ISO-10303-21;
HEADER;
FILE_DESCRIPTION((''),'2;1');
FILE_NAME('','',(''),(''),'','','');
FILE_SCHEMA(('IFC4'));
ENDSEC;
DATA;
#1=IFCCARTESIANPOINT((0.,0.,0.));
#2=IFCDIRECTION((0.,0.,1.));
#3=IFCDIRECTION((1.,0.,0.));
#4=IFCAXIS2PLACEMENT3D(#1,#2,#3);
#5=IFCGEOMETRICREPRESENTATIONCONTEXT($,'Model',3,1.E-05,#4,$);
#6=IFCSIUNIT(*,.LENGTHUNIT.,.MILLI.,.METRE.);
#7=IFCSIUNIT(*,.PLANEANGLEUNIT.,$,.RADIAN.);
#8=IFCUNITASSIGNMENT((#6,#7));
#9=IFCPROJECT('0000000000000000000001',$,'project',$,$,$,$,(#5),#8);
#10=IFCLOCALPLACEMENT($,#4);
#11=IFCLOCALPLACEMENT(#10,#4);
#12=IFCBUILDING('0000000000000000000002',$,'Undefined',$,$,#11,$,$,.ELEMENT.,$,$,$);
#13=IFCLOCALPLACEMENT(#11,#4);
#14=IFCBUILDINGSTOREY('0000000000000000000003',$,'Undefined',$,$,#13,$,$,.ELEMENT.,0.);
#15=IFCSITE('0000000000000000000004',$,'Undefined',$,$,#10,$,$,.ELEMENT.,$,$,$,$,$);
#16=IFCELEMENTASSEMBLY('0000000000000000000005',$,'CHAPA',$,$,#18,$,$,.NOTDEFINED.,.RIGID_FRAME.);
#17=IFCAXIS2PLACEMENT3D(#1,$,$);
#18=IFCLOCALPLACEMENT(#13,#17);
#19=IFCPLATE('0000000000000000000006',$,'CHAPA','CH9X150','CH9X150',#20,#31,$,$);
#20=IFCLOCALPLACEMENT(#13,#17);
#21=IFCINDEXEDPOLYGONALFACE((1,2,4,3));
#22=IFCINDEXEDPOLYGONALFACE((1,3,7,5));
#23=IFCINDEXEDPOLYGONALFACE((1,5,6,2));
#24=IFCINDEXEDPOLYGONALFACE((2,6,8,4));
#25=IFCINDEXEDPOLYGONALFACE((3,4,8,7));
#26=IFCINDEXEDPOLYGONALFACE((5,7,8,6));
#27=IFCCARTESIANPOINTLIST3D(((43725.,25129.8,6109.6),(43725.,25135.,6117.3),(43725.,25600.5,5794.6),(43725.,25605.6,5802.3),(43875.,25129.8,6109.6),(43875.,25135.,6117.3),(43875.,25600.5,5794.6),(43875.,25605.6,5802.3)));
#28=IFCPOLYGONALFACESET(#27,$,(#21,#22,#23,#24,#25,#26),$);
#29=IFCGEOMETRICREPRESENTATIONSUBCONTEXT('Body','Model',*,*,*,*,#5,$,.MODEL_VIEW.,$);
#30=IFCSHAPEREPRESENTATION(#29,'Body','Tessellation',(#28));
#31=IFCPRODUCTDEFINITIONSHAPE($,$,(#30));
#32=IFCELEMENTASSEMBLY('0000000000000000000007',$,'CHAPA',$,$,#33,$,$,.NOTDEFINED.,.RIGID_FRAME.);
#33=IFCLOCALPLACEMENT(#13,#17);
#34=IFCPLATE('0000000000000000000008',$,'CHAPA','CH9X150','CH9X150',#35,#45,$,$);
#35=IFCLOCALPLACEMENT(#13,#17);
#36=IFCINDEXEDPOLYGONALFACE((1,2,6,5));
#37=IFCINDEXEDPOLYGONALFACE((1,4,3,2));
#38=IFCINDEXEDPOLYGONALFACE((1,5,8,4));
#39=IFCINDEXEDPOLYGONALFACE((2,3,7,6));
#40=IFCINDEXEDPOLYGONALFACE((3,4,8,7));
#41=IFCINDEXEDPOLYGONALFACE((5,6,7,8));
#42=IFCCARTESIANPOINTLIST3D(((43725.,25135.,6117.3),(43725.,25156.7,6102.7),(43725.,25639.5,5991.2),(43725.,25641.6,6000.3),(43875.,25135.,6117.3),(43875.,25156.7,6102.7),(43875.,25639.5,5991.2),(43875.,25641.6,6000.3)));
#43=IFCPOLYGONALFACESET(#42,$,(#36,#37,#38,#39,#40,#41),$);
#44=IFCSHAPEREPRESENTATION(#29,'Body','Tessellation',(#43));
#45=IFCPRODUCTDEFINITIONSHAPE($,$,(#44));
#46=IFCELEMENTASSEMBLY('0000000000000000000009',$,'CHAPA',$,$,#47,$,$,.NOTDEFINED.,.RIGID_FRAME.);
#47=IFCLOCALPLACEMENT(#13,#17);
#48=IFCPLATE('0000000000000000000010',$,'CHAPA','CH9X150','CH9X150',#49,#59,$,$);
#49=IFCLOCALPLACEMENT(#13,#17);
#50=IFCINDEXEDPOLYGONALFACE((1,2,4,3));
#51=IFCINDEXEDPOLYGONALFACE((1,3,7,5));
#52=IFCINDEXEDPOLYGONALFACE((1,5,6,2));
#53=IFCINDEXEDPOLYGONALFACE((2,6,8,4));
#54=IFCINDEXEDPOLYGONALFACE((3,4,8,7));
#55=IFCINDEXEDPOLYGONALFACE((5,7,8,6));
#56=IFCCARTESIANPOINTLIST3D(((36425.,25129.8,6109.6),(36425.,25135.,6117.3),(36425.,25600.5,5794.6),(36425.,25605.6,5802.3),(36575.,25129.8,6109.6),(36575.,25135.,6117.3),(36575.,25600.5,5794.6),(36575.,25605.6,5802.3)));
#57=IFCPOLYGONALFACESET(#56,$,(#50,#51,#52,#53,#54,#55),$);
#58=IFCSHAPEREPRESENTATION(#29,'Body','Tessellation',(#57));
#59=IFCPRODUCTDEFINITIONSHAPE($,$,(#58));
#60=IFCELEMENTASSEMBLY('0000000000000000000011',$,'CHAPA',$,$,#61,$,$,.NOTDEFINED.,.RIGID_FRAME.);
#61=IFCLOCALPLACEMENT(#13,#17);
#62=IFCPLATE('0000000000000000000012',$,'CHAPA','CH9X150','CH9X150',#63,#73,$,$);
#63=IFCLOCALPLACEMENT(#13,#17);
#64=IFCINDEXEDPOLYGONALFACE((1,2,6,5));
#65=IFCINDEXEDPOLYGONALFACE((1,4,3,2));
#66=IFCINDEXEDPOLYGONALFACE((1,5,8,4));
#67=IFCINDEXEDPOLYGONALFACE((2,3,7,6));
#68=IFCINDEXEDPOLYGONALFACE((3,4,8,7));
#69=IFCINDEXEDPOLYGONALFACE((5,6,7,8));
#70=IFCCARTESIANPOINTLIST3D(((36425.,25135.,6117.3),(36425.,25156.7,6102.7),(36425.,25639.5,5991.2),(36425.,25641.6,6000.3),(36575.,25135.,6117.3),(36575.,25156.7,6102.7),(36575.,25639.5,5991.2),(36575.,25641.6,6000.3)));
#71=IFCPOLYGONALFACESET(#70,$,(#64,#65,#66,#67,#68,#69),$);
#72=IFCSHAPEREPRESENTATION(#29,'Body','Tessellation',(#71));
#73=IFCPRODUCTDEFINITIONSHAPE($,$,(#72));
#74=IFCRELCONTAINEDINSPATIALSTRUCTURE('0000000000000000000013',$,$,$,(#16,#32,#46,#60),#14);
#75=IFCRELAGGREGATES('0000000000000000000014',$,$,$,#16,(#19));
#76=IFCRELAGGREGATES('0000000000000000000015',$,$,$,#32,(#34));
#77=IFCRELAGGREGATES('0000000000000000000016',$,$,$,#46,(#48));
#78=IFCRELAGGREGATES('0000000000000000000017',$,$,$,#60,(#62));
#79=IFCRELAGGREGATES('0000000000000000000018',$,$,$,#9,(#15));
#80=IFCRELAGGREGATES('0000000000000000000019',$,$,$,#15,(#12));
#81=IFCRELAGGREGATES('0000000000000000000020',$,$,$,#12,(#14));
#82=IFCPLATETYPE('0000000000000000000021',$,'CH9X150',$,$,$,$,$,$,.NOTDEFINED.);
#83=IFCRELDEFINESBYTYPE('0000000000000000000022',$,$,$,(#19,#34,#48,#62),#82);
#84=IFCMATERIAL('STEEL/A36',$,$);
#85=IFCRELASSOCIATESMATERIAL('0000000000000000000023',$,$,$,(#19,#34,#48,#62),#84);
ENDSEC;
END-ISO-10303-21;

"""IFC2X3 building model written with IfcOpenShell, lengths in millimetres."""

from ifc_helpers import new_model, si_unit, frame, origin_with_axes, place, context, subcontext, project, spatial, polyline, outline, extrude, clip, halfspace, material, type_object, element, aggregate, save


model = new_model("IFC2X3")

# Units and contexts
model_context = context("Model", 3, precision=1e-05, world=origin_with_axes())
body_context = subcontext(model_context, "Body", "Model", "MODEL_VIEW")
ifc_project = project(units=[si_unit("LENGTHUNIT", "METRE", prefix="MILLI"), si_unit("PLANEANGLEUNIT", "RADIAN")], contexts=[model_context])

# Site, building, storey
site_placement = place(None, origin_with_axes())
site = spatial("IfcSite", under=ifc_project, at=site_placement, Name="Undefined", CompositionType="ELEMENT")
building_placement = place(site_placement, origin_with_axes())
building = spatial("IfcBuilding", under=site, at=building_placement, Name="Undefined", CompositionType="ELEMENT")
storey_placement = place(building_placement, origin_with_axes())
storey = spatial("IfcBuildingStorey", under=building, at=storey_placement, Name="Undefined", CompositionType="ELEMENT", Elevation=0.0)

# Shared definitions
ifc_material_1 = material(Name="STEEL/A36")

# Element assemblies, plates
assembly_1_placement = place(storey_placement, origin_with_axes())
assembly_1 = element("IfcElementAssembly", 1, at=assembly_1_placement, inside=storey, Name="CHAPA", AssemblyPlace="NOTDEFINED", PredefinedType="RIGID_FRAME")
plate_type_1 = type_object("IfcPlateType", Name="CH9X150", PredefinedType="NOTDEFINED")
plate_1_placement = place(assembly_1_placement, frame((43875.0, 25132.4, 6113.5), z_axis=(0.0, -0.55615, -0.831082), x_axis=(-1.0, 0.0, 0.0)))
plate_1 = element("IfcPlate", 2, at=plate_1_placement, type_object=plate_type_1, material=ifc_material_1, Name="CHAPA", Description="CH9X150", ObjectType="CH9X150", context=body_context, shape_type="SweptSolid", body=[
    extrude(outline(polyline([(0.0, 0.0), (150.0, 0.0), (150.0, 566.3), (0.0, 566.3), (0.0, 0.0)])), frame((0.0, 0.0, -4.7), z_axis=(0.0, 0.0, 1.0), x_axis=(1.0, 0.0, 0.0)), (0.0, 0.0, 1.0), 9.3),
])
aggregate(assembly_1, [plate_1])
assembly_2_placement = place(storey_placement, origin_with_axes())
assembly_2 = element("IfcElementAssembly", 3, at=assembly_2_placement, inside=storey, Name="CHAPA", AssemblyPlace="NOTDEFINED", PredefinedType="RIGID_FRAME")
plate_2_placement = place(assembly_2_placement, frame((43875.0, 25640.6, 5995.7), z_axis=(0.0, -0.225124, -0.97433), x_axis=(0.0, -0.97433, 0.225124)))
plate_2 = element("IfcPlate", 4, at=plate_2_placement, type_object=plate_type_1, material=ifc_material_1, Name="CHAPA", Description="CH9X150", ObjectType="CH9X150", context=body_context, shape_type="Clipping", body=[
    clip(extrude(outline(polyline([(0.0, 0.0), (520.0, 0.0), (520.0, 150.0), (0.0, 150.0), (0.0, 0.0)])), frame((0.0, 0.0, -4.7), z_axis=(0.0, 0.0, 1.0), x_axis=(1.0, 0.0, 0.0)), (0.0, 0.0, 1.0), 9.3), halfspace(frame((520.0, -500.0, -4.7), z_axis=(0.354778, 0.0, 0.934951), x_axis=(-0.934951, 0.0, 0.354778)), False)),
])
aggregate(assembly_2, [plate_2])
assembly_3_placement = place(storey_placement, origin_with_axes())
assembly_3 = element("IfcElementAssembly", 5, at=assembly_3_placement, inside=storey, Name="CHAPA", AssemblyPlace="NOTDEFINED", PredefinedType="RIGID_FRAME")
plate_3_placement = place(assembly_3_placement, frame((36575.0, 25132.4, 6113.5), z_axis=(0.0, -0.55615, -0.831082), x_axis=(-1.0, 0.0, 0.0)))
plate_3 = element("IfcPlate", 6, at=plate_3_placement, type_object=plate_type_1, material=ifc_material_1, Name="CHAPA", Description="CH9X150", ObjectType="CH9X150", context=body_context, shape_type="SweptSolid", body=[
    extrude(outline(polyline([(0.0, 0.0), (150.0, 0.0), (150.0, 566.3), (0.0, 566.3), (0.0, 0.0)])), frame((0.0, 0.0, -4.7), z_axis=(0.0, 0.0, 1.0), x_axis=(1.0, 0.0, 0.0)), (0.0, 0.0, 1.0), 9.3),
])
aggregate(assembly_3, [plate_3])
assembly_4_placement = place(storey_placement, origin_with_axes())
assembly_4 = element("IfcElementAssembly", 7, at=assembly_4_placement, inside=storey, Name="CHAPA", AssemblyPlace="NOTDEFINED", PredefinedType="RIGID_FRAME")
plate_4_placement = place(assembly_4_placement, frame((36575.0, 25640.6, 5995.7), z_axis=(0.0, -0.225124, -0.97433), x_axis=(0.0, -0.97433, 0.225124)))
plate_4 = element("IfcPlate", 8, at=plate_4_placement, type_object=plate_type_1, material=ifc_material_1, Name="CHAPA", Description="CH9X150", ObjectType="CH9X150", context=body_context, shape_type="Clipping", body=[
    clip(extrude(outline(polyline([(0.0, 0.0), (520.0, 0.0), (520.0, 150.0), (0.0, 150.0), (0.0, 0.0)])), frame((0.0, 0.0, -4.7), z_axis=(0.0, 0.0, 1.0), x_axis=(1.0, 0.0, 0.0)), (0.0, 0.0, 1.0), 9.3), halfspace(frame((520.0, -500.0, -4.7), z_axis=(0.354778, 0.0, 0.934951), x_axis=(-0.934951, 0.0, 0.354778)), False)),
])
aggregate(assembly_4, [plate_4])

save(model, "model.ifc")
